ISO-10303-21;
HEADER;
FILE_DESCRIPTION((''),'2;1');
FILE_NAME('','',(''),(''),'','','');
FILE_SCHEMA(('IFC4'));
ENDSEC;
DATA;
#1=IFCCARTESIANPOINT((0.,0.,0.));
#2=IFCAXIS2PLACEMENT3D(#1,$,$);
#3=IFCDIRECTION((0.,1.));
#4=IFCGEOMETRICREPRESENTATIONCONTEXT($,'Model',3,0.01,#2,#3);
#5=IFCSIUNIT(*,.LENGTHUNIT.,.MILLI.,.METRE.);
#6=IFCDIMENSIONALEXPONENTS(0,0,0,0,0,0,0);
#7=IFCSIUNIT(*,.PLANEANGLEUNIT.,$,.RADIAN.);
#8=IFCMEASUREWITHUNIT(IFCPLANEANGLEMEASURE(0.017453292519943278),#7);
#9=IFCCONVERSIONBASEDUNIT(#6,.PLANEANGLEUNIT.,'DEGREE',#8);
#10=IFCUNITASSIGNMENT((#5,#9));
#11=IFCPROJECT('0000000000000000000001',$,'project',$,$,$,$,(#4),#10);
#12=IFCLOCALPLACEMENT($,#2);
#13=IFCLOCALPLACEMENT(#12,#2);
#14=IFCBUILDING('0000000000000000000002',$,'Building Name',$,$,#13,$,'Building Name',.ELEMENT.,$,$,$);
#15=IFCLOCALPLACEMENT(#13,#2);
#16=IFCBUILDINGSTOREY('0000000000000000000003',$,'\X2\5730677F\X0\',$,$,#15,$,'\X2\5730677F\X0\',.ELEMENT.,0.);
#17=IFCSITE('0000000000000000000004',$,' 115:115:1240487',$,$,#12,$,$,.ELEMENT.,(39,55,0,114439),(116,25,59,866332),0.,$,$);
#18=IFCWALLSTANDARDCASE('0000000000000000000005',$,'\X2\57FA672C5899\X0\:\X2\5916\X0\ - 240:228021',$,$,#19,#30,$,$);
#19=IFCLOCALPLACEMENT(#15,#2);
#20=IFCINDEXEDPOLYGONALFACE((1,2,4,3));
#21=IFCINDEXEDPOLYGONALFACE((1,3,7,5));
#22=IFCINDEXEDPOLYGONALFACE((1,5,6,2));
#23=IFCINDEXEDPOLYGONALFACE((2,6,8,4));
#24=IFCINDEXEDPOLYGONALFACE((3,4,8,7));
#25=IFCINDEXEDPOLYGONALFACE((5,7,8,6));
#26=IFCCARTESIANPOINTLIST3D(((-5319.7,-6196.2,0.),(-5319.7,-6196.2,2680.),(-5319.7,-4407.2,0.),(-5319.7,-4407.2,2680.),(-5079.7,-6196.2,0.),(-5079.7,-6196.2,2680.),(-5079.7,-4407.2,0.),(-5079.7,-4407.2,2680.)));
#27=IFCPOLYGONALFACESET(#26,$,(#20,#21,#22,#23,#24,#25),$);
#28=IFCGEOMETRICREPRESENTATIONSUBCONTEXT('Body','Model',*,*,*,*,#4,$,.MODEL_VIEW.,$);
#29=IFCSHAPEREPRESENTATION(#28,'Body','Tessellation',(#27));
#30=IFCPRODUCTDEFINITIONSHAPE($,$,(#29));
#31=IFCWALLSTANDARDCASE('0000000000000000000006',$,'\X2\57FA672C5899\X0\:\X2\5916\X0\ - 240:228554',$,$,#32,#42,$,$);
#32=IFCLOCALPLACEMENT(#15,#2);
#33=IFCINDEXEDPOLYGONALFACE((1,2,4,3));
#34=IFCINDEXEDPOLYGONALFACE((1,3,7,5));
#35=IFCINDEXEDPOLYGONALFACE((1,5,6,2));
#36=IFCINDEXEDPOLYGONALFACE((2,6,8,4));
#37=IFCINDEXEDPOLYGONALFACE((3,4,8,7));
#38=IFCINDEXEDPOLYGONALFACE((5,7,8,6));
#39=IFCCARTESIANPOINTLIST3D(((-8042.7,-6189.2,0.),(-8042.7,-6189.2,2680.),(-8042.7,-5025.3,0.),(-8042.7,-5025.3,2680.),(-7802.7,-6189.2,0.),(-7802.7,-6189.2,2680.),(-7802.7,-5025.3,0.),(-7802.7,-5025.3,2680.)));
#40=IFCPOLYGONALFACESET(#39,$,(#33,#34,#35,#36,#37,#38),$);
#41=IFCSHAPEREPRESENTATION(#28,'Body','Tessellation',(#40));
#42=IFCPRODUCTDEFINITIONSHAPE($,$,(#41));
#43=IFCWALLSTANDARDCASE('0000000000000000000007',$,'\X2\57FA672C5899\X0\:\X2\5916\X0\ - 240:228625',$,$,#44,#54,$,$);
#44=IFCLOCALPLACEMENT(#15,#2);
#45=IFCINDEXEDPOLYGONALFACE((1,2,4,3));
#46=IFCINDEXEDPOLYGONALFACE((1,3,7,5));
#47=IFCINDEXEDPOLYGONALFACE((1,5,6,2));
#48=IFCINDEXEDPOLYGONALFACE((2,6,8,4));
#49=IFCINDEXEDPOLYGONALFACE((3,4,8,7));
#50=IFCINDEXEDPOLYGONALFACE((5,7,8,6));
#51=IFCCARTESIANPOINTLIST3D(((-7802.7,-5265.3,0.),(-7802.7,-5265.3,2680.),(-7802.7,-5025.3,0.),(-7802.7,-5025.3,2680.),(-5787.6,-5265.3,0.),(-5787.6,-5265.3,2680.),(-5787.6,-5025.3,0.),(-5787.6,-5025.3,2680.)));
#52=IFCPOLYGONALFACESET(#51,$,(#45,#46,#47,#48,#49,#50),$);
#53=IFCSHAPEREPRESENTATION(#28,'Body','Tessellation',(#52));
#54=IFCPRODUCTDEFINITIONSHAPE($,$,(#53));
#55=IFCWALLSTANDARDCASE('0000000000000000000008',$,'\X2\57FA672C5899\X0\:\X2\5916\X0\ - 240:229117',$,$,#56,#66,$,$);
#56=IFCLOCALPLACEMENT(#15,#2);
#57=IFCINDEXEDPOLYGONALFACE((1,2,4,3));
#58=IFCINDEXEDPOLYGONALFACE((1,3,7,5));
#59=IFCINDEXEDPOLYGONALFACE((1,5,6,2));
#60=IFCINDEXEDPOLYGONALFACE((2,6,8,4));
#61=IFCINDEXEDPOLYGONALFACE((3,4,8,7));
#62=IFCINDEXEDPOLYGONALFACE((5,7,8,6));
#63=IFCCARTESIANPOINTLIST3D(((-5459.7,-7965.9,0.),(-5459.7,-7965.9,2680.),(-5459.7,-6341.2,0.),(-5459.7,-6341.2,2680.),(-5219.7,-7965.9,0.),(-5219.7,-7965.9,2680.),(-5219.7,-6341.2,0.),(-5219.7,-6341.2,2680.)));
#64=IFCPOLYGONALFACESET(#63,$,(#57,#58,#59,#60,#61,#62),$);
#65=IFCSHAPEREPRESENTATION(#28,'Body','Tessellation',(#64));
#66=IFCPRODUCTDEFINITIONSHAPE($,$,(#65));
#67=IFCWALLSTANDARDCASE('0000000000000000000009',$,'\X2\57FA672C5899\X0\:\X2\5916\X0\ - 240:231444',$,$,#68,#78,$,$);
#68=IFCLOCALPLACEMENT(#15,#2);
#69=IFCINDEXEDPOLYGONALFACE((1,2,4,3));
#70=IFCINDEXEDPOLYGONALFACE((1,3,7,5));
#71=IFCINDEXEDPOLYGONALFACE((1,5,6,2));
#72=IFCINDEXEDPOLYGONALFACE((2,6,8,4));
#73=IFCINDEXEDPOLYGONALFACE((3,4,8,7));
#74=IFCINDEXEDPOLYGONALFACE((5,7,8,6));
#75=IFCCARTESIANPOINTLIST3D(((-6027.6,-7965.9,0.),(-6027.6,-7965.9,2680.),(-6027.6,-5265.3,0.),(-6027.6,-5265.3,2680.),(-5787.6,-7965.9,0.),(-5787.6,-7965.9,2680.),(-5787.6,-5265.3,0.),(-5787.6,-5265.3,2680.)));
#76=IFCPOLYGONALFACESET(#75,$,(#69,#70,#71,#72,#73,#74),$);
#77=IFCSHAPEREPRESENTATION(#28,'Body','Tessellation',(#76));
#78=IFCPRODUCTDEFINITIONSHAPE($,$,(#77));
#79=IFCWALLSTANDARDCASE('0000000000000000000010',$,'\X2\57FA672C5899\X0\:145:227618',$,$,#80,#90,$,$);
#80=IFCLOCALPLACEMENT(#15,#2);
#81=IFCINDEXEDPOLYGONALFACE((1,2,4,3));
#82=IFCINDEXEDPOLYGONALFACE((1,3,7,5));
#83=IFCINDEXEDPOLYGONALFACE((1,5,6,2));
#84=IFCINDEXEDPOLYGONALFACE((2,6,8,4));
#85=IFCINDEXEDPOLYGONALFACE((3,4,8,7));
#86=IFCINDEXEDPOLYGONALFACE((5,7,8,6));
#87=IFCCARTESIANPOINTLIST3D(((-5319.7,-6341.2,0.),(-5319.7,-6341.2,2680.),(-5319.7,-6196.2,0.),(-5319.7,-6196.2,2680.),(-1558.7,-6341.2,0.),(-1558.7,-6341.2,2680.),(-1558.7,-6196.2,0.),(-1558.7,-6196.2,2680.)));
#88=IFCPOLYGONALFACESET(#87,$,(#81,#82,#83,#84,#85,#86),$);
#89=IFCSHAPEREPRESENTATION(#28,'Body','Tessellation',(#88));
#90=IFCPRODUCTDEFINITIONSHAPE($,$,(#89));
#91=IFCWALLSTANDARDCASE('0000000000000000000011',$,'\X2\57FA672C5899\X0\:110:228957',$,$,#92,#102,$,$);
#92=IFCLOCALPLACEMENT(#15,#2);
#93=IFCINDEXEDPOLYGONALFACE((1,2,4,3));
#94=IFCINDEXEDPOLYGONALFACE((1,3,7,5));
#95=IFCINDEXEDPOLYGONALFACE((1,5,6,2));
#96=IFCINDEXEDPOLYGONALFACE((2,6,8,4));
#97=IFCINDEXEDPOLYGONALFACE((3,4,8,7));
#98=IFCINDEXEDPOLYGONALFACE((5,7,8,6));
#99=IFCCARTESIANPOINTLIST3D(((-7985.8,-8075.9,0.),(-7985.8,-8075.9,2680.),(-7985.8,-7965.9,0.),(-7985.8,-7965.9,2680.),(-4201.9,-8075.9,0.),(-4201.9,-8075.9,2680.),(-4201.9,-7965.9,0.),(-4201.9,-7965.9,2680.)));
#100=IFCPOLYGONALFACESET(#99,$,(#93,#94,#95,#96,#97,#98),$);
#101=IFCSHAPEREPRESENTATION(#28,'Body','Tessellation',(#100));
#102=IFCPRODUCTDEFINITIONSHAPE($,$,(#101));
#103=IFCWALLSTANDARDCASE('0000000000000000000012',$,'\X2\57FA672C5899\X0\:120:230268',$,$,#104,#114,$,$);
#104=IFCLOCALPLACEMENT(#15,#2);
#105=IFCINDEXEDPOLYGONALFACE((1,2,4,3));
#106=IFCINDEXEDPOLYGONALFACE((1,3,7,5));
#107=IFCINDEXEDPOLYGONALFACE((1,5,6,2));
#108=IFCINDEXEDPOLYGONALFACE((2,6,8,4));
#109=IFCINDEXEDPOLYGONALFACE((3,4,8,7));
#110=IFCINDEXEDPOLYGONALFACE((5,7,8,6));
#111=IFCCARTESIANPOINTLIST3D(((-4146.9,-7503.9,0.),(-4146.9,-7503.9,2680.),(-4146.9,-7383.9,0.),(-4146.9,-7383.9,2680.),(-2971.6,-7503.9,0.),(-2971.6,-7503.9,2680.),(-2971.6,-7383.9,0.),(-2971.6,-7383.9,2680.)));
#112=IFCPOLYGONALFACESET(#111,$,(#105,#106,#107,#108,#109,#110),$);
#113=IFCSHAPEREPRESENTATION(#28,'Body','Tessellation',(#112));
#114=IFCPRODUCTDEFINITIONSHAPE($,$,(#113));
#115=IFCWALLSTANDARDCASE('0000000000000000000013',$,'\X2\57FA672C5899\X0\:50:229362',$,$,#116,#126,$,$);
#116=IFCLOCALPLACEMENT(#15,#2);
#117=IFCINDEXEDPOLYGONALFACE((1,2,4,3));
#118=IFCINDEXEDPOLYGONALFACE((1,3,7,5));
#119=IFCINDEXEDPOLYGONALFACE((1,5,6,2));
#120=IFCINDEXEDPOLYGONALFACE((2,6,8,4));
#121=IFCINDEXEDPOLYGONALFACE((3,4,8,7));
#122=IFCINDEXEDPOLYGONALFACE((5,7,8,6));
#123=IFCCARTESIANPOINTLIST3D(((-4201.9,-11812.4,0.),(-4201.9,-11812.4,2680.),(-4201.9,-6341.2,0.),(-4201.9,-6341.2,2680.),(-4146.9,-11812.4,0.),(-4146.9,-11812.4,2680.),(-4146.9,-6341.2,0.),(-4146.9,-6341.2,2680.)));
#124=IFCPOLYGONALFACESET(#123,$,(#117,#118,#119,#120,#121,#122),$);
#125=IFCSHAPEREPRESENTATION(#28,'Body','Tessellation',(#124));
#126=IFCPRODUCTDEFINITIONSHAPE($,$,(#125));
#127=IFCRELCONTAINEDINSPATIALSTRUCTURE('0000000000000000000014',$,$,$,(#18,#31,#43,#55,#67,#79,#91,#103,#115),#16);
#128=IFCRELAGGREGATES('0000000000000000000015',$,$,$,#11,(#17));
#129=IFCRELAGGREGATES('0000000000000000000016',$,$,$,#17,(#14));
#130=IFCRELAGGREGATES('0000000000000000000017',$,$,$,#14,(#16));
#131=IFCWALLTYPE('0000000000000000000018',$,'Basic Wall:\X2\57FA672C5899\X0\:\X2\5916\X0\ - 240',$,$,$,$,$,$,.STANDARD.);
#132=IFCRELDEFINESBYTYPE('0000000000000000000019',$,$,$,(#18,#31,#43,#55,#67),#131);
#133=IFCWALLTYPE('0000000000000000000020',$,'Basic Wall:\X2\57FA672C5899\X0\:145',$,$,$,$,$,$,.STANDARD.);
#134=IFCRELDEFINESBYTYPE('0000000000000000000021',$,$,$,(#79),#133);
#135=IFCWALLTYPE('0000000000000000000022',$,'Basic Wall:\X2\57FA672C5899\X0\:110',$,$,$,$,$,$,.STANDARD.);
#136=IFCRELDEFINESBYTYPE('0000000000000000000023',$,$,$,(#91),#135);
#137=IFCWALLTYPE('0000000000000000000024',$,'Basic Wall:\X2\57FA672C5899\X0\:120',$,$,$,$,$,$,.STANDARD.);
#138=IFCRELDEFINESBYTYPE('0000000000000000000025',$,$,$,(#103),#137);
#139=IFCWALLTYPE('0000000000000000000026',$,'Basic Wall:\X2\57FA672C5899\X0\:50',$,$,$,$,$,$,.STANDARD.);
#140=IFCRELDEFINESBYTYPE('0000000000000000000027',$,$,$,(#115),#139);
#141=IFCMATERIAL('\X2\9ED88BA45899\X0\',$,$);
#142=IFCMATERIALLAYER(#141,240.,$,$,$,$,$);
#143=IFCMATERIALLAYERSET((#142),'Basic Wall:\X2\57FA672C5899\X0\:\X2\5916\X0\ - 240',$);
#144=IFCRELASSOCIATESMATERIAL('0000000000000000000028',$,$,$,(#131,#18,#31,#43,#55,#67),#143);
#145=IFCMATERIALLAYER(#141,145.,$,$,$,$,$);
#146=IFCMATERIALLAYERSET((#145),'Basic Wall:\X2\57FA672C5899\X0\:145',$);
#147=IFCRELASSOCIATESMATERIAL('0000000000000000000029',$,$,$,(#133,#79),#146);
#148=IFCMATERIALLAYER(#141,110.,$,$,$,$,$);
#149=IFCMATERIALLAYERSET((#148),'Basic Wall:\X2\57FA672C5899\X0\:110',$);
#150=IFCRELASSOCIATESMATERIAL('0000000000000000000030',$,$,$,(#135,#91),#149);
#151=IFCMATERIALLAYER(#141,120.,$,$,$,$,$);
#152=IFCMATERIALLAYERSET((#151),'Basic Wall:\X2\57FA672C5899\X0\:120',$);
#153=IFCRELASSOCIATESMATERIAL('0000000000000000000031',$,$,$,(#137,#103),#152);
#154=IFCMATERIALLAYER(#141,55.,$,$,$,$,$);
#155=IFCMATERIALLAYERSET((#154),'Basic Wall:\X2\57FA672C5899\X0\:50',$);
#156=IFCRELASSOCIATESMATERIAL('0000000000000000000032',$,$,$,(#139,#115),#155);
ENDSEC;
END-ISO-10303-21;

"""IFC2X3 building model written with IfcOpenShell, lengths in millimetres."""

from ifc_helpers import new_model, entity, si_unit, converted_unit, direction, frame, frame_2d, origin, place, context, subcontext, project, spatial, rectangle, extrude, material, layer, layer_set, layer_usage, type_object, element, save


model = new_model("IFC2X3")

# Units and contexts
model_context = context("Model", 3, precision=0.01, world=origin(), true_north=direction((0.0, 1.0)))
body_context = subcontext(model_context, "Body", "Model", "MODEL_VIEW")
ifc_project = project(units=[si_unit("LENGTHUNIT", "METRE", prefix="MILLI"), converted_unit("PLANEANGLEUNIT", "DEGREE", entity("IfcPlaneAngleMeasure", 0.017453292519943278), si_unit("PLANEANGLEUNIT", "RADIAN"), dimensions=[0, 0, 0, 0, 0, 0, 0])], contexts=[model_context])

# Site, building, storey
site_placement = place(None, origin())
site = spatial("IfcSite", under=ifc_project, at=site_placement, Name=" 115:115:1240487", CompositionType="ELEMENT", RefLatitude=(39, 55, 0, 114439), RefLongitude=(116, 25, 59, 866332), RefElevation=0.0)
building_placement = place(site_placement, origin())
building = spatial("IfcBuilding", under=site, at=building_placement, Name="Building Name", LongName="Building Name", CompositionType="ELEMENT")
storey_placement = place(building_placement, origin())
storey = spatial("IfcBuildingStorey", under=building, at=storey_placement, Name="地板", LongName="地板", CompositionType="ELEMENT", Elevation=0.0)

# Shared definitions
ifc_material_1 = material(Name="默认墙")
ifc_layer_1 = layer(ifc_material_1, 240.0)
ifc_layer_set_1 = layer_set([ifc_layer_1], Name="Basic Wall:基本墙:外 - 240")
wall_type_1 = type_object("IfcWallType", Name="Basic Wall:基本墙:外 - 240", PredefinedType="STANDARD", material=ifc_layer_set_1)

# Wall
ifc_layer_usage_1 = layer_usage(ifc_layer_set_1, "AXIS2", "NEGATIVE", 120.0)
wall_1_placement = place(storey_placement, frame((-5199.7, -4407.2, 0.0), z_axis=(0.0, 0.0, 1.0), x_axis=(0.0, -1.0, 0.0)))
element("IfcWallStandardCase", 1, at=wall_1_placement, inside=storey, type_object=wall_type_1, material=ifc_layer_usage_1, Name="基本墙:外 - 240:228021", context=body_context, shape_type="SweptSolid", body=[
    extrude(rectangle(XDim=1789.0, YDim=240.0, at=frame_2d((894.5, 0.0), x_axis=(-1.0, 0.0))), origin(), (0.0, 0.0, 1.0), 2680.0),
])

# Walls
ifc_layer_usage_2 = layer_usage(ifc_layer_set_1, "AXIS2", "NEGATIVE", 120.0)
wall_2_placement = place(storey_placement, frame((-7922.7, -5025.3, 0.0), z_axis=(0.0, 0.0, 1.0), x_axis=(0.0, -1.0, 0.0)))
element("IfcWallStandardCase", 2, at=wall_2_placement, inside=storey, type_object=wall_type_1, material=ifc_layer_usage_2, Name="基本墙:外 - 240:228554", context=body_context, shape_type="SweptSolid", body=[
    extrude(rectangle(XDim=1163.9, YDim=240.0, at=frame_2d((581.9, 0.0), x_axis=(-1.0, 0.0))), origin(), (0.0, 0.0, 1.0), 2680.0),
])
ifc_layer_usage_3 = layer_usage(ifc_layer_set_1, "AXIS2", "NEGATIVE", 120.0)
wall_3_placement = place(storey_placement, frame((-7802.7, -5145.3, 0.0)))
element("IfcWallStandardCase", 3, at=wall_3_placement, inside=storey, type_object=wall_type_1, material=ifc_layer_usage_3, Name="基本墙:外 - 240:228625", context=body_context, shape_type="SweptSolid", body=[
    extrude(rectangle(XDim=2015.1, YDim=240.0, at=frame_2d((1007.5, 0.0), x_axis=(-1.0, 0.0))), origin(), (0.0, 0.0, 1.0), 2680.0),
])
ifc_layer_usage_4 = layer_usage(ifc_layer_set_1, "AXIS2", "NEGATIVE", 120.0)
wall_4_placement = place(storey_placement, frame((-5339.7, -6341.2, 0.0), z_axis=(0.0, 0.0, 1.0), x_axis=(0.0, -1.0, 0.0)))
element("IfcWallStandardCase", 4, at=wall_4_placement, inside=storey, type_object=wall_type_1, material=ifc_layer_usage_4, Name="基本墙:外 - 240:229117", context=body_context, shape_type="SweptSolid", body=[
    extrude(rectangle(XDim=1624.7, YDim=240.0, at=frame_2d((812.3, 0.0), x_axis=(-1.0, 0.0))), origin(), (0.0, 0.0, 1.0), 2680.0),
])
ifc_layer_usage_5 = layer_usage(ifc_layer_set_1, "AXIS2", "NEGATIVE", 120.0)
wall_5_placement = place(storey_placement, frame((-5907.6, -5265.3, 0.0), z_axis=(0.0, 0.0, 1.0), x_axis=(0.0, -1.0, 0.0)))
element("IfcWallStandardCase", 5, at=wall_5_placement, inside=storey, type_object=wall_type_1, material=ifc_layer_usage_5, Name="基本墙:外 - 240:231444", context=body_context, shape_type="SweptSolid", body=[
    extrude(rectangle(XDim=2700.5, YDim=240.0, at=frame_2d((1350.3, 0.0), x_axis=(-1.0, 0.0))), origin(), (0.0, 0.0, 1.0), 2680.0),
])
ifc_layer_2 = layer(ifc_material_1, 145.0)
ifc_layer_set_2 = layer_set([ifc_layer_2], Name="Basic Wall:基本墙:145")
ifc_layer_usage_6 = layer_usage(ifc_layer_set_2, "AXIS2", "NEGATIVE", 72.5)
wall_type_2 = type_object("IfcWallType", Name="Basic Wall:基本墙:145", PredefinedType="STANDARD", material=ifc_layer_set_2)
wall_6_placement = place(storey_placement, frame((-5319.7, -6268.7, 0.0)))
element("IfcWallStandardCase", 6, at=wall_6_placement, inside=storey, type_object=wall_type_2, material=ifc_layer_usage_6, Name="基本墙:145:227618", context=body_context, shape_type="SweptSolid", body=[
    extrude(rectangle(XDim=3761.0, YDim=145.0, at=frame_2d((1880.5, 0.0), x_axis=(-1.0, 0.0))), origin(), (0.0, 0.0, 1.0), 2680.0),
])
ifc_layer_3 = layer(ifc_material_1, 110.0)
ifc_layer_set_3 = layer_set([ifc_layer_3], Name="Basic Wall:基本墙:110")
ifc_layer_usage_7 = layer_usage(ifc_layer_set_3, "AXIS2", "NEGATIVE", 55.0)
wall_type_3 = type_object("IfcWallType", Name="Basic Wall:基本墙:110", PredefinedType="STANDARD", material=ifc_layer_set_3)
wall_7_placement = place(storey_placement, frame((-7985.8, -8020.9, 0.0)))
element("IfcWallStandardCase", 7, at=wall_7_placement, inside=storey, type_object=wall_type_3, material=ifc_layer_usage_7, Name="基本墙:110:228957", context=body_context, shape_type="SweptSolid", body=[
    extrude(rectangle(XDim=3783.9, YDim=110.0, at=frame_2d((1891.9, 0.0), x_axis=(-1.0, 0.0))), origin(), (0.0, 0.0, 1.0), 2680.0),
])
ifc_layer_4 = layer(ifc_material_1, 120.0)
ifc_layer_set_4 = layer_set([ifc_layer_4], Name="Basic Wall:基本墙:120")
ifc_layer_usage_8 = layer_usage(ifc_layer_set_4, "AXIS2", "NEGATIVE", 60.0)
wall_type_4 = type_object("IfcWallType", Name="Basic Wall:基本墙:120", PredefinedType="STANDARD", material=ifc_layer_set_4)
wall_8_placement = place(storey_placement, frame((-4146.9, -7443.9, 0.0)))
element("IfcWallStandardCase", 8, at=wall_8_placement, inside=storey, type_object=wall_type_4, material=ifc_layer_usage_8, Name="基本墙:120:230268", context=body_context, shape_type="SweptSolid", body=[
    extrude(rectangle(XDim=1175.3, YDim=120.0, at=frame_2d((587.7, 0.0), x_axis=(-1.0, 0.0))), origin(), (0.0, 0.0, 1.0), 2680.0),
])
ifc_layer_5 = layer(ifc_material_1, 55.0)
ifc_layer_set_5 = layer_set([ifc_layer_5], Name="Basic Wall:基本墙:50")
ifc_layer_usage_9 = layer_usage(ifc_layer_set_5, "AXIS2", "NEGATIVE", 27.5)
wall_type_5 = type_object("IfcWallType", Name="Basic Wall:基本墙:50", PredefinedType="STANDARD", material=ifc_layer_set_5)
wall_9_placement = place(storey_placement, frame((-4174.4, -11812.4, 0.0), z_axis=(0.0, 0.0, 1.0), x_axis=(0.0, 1.0, 0.0)))
element("IfcWallStandardCase", 9, at=wall_9_placement, inside=storey, type_object=wall_type_5, material=ifc_layer_usage_9, Name="基本墙:50:229362", context=body_context, shape_type="SweptSolid", body=[
    extrude(rectangle(XDim=5471.2, YDim=55.0, at=frame_2d((2735.6, 0.0), x_axis=(-1.0, 0.0))), origin(), (0.0, 0.0, 1.0), 2680.0),
])

save(model, "model.ifc")
